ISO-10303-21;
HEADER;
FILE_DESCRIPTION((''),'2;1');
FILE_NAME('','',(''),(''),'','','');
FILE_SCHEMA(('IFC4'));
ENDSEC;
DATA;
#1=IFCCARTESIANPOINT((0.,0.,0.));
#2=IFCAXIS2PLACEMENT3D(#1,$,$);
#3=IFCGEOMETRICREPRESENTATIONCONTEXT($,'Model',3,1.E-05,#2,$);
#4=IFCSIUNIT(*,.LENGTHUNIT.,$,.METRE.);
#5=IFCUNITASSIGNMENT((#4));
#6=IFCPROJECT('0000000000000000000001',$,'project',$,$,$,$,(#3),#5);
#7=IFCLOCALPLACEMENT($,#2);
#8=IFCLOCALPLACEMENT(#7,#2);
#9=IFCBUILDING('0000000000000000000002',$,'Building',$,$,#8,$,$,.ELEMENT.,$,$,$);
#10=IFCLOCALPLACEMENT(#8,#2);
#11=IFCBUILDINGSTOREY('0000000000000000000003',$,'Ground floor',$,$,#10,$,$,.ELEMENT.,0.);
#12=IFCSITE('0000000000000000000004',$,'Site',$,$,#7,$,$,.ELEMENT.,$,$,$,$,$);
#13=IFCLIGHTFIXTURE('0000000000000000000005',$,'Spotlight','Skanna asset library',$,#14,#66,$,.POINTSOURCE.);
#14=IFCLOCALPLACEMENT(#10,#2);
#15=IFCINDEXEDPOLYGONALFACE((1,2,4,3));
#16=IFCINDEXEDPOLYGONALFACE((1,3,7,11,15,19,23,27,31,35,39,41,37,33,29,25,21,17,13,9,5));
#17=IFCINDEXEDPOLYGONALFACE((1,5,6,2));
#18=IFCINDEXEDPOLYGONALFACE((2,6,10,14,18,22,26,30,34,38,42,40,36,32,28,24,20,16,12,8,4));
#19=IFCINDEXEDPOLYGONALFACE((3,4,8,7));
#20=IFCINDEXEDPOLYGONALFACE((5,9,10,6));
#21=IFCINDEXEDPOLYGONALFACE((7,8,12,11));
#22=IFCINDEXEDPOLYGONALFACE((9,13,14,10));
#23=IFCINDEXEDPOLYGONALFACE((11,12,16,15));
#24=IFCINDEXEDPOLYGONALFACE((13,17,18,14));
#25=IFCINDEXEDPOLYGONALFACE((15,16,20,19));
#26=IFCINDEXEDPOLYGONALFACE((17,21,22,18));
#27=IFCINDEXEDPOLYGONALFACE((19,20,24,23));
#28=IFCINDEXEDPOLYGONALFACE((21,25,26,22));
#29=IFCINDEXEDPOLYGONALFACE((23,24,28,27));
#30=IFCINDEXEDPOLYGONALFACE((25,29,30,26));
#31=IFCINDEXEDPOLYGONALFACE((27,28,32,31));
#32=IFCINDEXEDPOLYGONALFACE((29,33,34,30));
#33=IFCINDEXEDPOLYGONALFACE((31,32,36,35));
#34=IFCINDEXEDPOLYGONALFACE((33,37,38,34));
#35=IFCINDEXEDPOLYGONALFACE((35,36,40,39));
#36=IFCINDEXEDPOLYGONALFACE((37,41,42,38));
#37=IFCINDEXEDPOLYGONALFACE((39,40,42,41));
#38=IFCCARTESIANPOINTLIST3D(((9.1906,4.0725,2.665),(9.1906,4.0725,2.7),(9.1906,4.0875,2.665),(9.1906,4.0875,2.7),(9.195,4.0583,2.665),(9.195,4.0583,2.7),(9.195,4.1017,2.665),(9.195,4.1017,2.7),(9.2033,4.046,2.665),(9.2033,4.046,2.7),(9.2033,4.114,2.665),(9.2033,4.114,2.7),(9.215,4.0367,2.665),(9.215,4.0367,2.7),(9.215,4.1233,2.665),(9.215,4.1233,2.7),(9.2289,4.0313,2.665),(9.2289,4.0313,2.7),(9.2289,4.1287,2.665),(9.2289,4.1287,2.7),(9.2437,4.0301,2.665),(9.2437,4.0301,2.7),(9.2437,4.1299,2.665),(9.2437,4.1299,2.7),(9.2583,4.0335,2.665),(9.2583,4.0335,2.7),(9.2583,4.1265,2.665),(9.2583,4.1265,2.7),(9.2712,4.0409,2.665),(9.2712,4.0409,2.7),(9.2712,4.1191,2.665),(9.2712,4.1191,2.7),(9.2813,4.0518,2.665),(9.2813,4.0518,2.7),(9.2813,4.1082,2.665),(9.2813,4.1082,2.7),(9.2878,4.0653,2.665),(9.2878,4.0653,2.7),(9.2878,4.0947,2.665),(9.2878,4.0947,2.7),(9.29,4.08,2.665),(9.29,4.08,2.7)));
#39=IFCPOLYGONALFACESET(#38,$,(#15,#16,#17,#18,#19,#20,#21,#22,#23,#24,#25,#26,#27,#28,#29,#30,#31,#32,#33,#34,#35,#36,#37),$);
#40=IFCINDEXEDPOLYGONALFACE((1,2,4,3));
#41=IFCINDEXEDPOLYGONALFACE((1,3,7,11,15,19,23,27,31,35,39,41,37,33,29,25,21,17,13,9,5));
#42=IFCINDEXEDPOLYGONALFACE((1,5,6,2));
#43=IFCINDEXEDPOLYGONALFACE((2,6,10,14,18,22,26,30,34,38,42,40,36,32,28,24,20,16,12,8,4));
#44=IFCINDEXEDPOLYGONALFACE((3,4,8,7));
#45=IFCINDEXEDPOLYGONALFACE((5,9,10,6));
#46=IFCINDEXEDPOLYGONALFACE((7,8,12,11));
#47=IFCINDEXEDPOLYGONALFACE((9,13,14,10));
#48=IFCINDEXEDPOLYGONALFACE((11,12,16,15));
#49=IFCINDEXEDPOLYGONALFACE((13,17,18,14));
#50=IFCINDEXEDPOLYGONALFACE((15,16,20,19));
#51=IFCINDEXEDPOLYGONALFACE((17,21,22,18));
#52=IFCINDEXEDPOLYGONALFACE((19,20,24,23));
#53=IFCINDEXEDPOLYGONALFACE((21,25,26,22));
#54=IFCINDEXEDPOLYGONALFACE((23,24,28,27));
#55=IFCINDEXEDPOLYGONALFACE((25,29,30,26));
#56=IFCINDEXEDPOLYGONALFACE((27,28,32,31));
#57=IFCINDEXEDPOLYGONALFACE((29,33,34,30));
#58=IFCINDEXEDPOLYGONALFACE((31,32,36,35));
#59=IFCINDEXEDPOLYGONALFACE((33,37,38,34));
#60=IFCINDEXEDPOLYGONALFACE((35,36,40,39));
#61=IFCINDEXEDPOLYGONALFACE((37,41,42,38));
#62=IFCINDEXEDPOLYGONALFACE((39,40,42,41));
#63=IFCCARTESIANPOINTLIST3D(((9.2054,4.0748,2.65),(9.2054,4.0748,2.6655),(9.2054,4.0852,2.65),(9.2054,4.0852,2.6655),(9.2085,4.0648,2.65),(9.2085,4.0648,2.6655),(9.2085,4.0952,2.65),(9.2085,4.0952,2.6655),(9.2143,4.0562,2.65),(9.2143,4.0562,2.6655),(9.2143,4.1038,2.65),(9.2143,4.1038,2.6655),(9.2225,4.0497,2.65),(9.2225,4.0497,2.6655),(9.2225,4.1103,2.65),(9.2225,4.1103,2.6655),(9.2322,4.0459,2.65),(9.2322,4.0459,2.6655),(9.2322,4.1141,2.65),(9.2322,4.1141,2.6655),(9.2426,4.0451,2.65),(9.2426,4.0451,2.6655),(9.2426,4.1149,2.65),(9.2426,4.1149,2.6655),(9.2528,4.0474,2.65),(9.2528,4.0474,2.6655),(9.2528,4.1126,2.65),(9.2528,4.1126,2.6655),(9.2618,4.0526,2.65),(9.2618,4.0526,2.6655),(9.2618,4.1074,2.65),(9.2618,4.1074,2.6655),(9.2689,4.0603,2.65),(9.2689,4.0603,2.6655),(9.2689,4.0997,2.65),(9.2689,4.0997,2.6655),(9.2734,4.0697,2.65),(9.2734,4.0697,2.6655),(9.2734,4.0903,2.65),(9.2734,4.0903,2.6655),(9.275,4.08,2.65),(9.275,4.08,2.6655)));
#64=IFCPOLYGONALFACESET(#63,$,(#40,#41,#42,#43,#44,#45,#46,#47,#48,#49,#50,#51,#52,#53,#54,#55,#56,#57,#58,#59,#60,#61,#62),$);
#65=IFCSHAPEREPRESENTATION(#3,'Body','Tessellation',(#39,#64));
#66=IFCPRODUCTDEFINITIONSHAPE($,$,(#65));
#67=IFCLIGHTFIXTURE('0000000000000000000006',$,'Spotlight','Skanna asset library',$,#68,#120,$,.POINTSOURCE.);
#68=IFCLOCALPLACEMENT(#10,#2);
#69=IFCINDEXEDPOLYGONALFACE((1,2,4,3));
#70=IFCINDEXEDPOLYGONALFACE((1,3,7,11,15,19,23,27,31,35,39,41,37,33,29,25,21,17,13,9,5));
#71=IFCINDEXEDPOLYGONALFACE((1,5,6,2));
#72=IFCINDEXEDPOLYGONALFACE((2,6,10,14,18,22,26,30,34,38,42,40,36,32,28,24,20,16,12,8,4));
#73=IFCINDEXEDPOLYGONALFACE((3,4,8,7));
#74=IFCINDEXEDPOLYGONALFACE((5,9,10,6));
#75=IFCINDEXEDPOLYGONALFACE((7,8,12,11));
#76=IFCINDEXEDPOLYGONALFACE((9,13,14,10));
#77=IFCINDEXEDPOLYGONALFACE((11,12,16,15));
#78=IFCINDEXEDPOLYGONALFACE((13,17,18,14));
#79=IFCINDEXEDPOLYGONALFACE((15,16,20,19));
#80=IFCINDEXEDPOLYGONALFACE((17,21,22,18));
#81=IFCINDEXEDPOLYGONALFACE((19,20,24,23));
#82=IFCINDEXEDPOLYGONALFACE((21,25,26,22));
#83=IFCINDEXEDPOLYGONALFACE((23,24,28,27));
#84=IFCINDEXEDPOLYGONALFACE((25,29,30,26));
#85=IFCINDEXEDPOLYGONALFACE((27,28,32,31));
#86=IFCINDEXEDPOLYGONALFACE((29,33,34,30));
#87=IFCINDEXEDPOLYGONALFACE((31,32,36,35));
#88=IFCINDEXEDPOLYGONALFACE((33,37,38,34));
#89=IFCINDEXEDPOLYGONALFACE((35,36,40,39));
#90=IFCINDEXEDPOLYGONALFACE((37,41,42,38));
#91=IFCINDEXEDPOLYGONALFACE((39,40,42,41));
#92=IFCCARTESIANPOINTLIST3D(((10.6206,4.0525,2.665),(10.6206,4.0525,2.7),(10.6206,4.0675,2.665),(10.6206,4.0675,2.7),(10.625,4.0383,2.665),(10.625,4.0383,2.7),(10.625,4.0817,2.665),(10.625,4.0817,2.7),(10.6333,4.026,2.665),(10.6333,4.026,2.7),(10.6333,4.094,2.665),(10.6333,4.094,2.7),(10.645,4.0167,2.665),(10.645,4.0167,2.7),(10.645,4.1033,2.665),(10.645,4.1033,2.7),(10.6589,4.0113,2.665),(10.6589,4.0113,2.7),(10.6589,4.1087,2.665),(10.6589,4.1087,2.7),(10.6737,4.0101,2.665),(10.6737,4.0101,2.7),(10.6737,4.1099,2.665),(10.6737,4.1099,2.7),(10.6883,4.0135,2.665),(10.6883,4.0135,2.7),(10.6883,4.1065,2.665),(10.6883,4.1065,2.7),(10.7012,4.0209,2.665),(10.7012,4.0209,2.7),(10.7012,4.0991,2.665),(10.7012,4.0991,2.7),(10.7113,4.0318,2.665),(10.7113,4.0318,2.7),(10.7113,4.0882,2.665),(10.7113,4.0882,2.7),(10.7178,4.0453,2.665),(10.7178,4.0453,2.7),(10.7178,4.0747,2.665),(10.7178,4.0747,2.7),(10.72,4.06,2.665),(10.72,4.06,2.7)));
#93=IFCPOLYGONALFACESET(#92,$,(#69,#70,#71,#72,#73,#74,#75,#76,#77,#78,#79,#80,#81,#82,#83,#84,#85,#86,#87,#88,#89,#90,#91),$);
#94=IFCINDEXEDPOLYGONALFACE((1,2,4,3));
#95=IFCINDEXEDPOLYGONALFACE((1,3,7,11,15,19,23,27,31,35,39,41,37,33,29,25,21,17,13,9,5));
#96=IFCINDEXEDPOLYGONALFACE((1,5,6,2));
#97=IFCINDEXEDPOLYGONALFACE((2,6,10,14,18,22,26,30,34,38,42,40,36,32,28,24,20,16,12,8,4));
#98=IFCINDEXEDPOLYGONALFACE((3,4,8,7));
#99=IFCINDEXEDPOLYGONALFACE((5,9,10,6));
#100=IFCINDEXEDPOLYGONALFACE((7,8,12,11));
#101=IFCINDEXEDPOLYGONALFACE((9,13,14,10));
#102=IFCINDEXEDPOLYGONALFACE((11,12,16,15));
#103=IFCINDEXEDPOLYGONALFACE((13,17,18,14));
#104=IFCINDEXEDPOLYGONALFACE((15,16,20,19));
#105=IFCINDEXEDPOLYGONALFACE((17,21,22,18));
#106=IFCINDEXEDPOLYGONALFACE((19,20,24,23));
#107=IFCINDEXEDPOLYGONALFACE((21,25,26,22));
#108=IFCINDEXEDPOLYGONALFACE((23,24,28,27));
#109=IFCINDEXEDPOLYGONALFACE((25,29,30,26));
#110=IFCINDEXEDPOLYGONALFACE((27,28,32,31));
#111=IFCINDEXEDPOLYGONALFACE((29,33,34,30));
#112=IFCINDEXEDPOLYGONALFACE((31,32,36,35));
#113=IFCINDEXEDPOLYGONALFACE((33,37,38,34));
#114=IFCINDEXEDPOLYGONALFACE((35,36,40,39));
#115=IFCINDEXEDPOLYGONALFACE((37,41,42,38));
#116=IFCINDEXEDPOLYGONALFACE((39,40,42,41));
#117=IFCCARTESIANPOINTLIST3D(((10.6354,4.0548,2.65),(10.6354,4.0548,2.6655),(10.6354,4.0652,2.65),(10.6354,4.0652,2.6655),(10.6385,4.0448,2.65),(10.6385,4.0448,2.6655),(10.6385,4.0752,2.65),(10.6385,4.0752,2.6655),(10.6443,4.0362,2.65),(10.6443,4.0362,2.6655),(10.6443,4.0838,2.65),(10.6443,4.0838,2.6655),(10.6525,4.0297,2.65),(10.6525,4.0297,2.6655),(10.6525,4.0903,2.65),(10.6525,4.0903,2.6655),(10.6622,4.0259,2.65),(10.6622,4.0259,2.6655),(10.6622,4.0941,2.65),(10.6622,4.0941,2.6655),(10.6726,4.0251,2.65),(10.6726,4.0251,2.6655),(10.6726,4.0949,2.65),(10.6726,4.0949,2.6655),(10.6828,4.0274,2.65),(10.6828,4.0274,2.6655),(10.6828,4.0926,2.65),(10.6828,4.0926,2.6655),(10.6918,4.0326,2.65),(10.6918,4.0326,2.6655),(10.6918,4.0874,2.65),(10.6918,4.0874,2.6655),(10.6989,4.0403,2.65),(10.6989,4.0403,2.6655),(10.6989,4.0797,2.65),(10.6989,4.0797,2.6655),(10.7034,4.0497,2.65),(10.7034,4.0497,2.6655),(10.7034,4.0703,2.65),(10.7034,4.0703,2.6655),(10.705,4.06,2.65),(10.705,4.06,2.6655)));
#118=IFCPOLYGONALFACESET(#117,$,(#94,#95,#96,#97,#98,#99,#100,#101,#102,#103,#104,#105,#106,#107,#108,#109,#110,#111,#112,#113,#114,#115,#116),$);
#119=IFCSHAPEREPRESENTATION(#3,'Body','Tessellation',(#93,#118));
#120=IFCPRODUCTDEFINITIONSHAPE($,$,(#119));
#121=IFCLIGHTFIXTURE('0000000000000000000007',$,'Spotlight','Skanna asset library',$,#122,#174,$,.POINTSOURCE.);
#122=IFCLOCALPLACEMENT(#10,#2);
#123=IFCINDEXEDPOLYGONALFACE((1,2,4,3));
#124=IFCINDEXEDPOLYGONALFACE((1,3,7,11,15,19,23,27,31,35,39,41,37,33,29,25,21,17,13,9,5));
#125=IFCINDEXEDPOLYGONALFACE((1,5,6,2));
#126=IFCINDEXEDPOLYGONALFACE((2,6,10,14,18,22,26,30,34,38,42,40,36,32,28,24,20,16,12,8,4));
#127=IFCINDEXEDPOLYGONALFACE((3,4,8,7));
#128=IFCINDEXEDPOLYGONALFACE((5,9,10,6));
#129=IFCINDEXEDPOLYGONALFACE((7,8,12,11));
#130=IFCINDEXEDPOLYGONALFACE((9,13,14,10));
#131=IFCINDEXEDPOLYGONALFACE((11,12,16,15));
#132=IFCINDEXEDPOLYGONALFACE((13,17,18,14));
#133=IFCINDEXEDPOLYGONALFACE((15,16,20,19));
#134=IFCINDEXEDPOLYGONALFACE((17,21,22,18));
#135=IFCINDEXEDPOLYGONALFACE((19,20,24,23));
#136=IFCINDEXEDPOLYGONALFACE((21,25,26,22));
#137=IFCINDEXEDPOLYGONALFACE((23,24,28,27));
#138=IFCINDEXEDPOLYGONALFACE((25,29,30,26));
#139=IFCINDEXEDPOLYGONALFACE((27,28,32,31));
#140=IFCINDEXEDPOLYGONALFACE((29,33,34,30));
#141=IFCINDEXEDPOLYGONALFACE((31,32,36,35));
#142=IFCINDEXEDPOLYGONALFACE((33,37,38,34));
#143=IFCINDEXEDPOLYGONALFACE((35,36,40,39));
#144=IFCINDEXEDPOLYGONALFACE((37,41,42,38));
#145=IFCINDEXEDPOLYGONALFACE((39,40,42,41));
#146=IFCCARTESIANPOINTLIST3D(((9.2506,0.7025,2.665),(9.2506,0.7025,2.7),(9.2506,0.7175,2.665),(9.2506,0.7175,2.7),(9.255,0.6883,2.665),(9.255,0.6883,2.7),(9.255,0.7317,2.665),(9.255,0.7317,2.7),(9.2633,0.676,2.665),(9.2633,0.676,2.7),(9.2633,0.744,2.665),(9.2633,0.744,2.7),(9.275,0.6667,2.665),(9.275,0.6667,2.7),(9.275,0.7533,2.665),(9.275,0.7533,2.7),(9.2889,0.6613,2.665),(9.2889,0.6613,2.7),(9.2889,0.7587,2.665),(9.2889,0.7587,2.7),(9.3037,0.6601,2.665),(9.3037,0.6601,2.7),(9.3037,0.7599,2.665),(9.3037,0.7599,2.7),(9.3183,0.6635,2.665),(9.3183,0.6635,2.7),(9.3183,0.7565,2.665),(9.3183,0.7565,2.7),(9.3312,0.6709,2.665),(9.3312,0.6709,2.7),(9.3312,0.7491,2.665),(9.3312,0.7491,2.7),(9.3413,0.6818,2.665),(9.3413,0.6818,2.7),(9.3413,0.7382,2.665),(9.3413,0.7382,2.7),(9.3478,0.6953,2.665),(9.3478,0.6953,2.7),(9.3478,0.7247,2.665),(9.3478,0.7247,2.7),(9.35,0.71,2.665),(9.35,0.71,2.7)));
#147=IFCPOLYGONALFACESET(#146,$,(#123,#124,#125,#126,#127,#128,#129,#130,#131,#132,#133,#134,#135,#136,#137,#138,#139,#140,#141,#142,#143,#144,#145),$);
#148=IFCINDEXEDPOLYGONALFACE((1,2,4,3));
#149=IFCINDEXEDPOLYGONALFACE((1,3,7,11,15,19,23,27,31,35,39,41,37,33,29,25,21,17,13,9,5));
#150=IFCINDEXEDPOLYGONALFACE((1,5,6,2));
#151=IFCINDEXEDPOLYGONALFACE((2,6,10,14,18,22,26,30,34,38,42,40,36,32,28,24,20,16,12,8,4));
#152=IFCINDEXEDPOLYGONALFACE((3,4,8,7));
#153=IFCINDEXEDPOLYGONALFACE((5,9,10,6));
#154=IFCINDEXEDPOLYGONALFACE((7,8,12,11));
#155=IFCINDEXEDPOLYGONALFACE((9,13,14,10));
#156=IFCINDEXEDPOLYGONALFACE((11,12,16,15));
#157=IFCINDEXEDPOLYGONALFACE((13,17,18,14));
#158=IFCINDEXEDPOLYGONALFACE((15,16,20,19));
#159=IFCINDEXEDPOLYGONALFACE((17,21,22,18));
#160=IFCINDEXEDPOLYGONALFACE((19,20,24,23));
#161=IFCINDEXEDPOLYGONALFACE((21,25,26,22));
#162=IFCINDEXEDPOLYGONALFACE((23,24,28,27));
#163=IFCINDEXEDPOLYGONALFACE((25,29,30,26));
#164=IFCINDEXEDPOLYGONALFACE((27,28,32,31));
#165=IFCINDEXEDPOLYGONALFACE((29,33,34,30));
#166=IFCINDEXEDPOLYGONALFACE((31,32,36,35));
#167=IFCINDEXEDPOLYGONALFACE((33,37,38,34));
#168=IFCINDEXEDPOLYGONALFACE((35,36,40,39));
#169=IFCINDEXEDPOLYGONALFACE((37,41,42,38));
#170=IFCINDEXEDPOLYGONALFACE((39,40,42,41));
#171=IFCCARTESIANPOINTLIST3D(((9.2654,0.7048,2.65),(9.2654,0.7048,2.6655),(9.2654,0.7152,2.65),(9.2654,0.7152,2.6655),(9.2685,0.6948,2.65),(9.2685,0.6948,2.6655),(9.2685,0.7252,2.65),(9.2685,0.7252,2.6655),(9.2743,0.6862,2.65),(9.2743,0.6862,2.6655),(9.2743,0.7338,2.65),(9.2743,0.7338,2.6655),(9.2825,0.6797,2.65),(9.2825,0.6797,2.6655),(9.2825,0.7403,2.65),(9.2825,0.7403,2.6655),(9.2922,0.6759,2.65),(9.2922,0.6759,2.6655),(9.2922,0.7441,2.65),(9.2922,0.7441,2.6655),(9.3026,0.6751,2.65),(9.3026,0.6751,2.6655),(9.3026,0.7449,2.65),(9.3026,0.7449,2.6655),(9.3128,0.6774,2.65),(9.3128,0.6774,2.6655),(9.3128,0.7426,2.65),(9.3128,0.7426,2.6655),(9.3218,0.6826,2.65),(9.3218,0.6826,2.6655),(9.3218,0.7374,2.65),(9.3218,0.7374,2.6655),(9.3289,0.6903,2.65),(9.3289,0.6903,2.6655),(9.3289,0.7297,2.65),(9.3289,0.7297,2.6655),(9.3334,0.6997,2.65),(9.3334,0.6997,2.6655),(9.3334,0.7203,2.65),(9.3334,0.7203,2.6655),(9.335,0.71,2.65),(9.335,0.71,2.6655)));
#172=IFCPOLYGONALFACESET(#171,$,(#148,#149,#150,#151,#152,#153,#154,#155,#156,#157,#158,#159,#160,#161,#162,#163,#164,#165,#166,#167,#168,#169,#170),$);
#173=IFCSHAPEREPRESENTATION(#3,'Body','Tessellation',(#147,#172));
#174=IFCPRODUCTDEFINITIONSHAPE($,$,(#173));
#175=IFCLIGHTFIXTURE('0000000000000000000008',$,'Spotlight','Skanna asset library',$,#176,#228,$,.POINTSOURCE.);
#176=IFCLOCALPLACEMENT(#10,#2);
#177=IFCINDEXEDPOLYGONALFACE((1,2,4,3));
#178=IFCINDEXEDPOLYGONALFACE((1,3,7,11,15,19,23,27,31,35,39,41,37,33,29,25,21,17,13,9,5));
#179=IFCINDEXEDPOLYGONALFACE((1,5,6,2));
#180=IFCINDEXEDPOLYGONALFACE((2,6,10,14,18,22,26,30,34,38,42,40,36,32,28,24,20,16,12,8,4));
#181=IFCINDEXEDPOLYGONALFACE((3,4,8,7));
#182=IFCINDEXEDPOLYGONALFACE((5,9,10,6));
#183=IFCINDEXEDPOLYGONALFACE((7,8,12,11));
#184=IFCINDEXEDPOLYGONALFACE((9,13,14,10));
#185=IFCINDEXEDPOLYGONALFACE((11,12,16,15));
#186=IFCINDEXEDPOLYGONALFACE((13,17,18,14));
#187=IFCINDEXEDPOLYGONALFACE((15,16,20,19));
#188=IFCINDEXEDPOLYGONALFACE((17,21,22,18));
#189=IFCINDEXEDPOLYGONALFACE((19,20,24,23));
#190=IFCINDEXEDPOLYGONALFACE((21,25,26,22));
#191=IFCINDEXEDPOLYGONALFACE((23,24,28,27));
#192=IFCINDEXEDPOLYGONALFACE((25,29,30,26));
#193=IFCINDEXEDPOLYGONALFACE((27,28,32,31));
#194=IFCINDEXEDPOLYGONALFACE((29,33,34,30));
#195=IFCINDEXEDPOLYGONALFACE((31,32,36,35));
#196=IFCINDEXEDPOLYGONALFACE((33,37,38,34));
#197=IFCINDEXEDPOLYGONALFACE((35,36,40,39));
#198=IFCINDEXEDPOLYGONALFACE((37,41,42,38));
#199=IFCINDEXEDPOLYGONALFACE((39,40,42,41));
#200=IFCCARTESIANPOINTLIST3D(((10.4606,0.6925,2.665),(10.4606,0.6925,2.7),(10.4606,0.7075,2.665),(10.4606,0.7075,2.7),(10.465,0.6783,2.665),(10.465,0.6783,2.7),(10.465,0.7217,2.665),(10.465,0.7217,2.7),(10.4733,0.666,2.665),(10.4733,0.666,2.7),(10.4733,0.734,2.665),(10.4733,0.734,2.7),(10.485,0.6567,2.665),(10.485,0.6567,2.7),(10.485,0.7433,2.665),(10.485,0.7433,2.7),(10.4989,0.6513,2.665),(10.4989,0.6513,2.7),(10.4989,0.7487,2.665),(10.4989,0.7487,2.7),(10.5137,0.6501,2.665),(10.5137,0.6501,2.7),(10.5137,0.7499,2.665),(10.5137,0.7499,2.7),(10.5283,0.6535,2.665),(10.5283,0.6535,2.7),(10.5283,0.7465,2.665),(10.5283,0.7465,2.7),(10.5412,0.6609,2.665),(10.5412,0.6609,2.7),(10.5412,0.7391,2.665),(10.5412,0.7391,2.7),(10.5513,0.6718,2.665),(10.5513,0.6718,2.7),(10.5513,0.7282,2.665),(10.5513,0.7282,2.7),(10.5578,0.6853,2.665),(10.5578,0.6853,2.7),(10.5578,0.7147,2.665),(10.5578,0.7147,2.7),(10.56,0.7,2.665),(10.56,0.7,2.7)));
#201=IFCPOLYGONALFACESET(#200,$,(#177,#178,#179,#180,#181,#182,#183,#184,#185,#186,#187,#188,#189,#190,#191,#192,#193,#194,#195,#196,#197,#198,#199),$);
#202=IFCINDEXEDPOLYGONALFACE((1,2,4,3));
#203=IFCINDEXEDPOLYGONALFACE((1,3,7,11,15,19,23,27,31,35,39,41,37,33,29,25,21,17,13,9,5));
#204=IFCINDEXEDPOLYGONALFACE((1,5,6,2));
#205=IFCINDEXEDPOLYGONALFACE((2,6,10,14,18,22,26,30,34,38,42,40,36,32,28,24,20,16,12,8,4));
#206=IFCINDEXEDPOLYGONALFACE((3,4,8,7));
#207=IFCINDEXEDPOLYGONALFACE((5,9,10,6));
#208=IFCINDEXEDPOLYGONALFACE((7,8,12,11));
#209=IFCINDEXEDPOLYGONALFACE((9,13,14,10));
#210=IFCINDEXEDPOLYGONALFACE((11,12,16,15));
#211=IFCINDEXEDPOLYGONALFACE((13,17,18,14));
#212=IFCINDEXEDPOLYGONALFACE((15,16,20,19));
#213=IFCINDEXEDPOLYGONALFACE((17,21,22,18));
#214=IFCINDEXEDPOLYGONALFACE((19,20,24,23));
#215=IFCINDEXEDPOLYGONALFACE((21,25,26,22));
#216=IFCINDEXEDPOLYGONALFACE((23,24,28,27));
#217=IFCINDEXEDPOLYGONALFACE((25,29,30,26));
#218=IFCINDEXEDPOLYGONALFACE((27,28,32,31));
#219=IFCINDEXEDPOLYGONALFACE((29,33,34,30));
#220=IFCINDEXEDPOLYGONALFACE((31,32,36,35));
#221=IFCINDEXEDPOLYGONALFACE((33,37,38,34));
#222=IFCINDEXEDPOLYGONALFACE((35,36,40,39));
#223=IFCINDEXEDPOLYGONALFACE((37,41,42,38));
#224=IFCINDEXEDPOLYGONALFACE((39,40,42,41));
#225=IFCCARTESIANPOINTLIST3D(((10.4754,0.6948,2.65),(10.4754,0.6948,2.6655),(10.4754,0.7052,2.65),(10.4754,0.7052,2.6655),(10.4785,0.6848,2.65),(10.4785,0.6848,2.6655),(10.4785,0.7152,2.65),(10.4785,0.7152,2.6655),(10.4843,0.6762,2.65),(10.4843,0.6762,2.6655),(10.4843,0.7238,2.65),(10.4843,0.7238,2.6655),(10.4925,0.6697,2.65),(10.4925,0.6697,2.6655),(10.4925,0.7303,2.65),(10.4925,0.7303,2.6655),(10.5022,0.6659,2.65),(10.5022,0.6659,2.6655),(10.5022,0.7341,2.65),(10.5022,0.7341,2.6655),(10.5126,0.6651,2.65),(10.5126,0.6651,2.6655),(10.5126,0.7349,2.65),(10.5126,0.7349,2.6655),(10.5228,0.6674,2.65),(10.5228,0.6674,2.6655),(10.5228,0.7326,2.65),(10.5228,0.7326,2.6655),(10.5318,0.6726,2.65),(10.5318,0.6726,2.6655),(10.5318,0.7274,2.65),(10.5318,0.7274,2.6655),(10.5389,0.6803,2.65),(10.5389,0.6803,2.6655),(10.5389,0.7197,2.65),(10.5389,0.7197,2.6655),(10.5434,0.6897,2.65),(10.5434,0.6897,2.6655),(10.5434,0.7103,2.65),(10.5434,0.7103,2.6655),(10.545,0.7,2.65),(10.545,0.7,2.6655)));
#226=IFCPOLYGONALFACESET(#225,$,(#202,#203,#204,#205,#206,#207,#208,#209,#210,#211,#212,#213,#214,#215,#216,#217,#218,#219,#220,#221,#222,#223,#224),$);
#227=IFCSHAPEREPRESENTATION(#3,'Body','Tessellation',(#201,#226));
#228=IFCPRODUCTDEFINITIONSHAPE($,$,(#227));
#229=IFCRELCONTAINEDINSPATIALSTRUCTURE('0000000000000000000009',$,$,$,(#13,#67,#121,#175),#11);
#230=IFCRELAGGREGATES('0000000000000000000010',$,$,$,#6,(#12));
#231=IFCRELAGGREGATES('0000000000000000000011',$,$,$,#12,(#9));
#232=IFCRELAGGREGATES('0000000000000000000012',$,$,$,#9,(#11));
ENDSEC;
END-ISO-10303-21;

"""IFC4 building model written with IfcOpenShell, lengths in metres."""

from ifc_helpers import new_model, si_unit, frame, origin, origin_2d, place, context, project, spatial, circle, extrude, element, save


model = new_model("IFC4")

# Units and contexts
model_context = context("Model", 3, precision=1e-05, world=origin())
ifc_project = project(units=[si_unit("LENGTHUNIT", "METRE")], contexts=[model_context])

# Site, building, storey
site_placement = place(None, origin())
site = spatial("IfcSite", under=ifc_project, at=site_placement, Name="Site", CompositionType="ELEMENT")
building_placement = place(site_placement, origin())
building = spatial("IfcBuilding", under=site, at=building_placement, Name="Building", CompositionType="ELEMENT")
storey_placement = place(building_placement, origin())
storey = spatial("IfcBuildingStorey", under=building, at=storey_placement, Name="Ground floor", CompositionType="ELEMENT", Elevation=0.0)

# Light fixtures
for number, where, z_axis, x_axis, name in (
    (1, (9.24, 4.08, 2.65), (0.0, 0.0, 1.0), (1.0, 0.0, 0.0), "Spotlight"),
    (2, (10.67, 4.06, 2.65), (0.0, 0.0, 1.0), (1.0, 0.0, 0.0), "Spotlight"),
    (3, (9.3, 0.71, 2.65), (0.0, 0.0, 1.0), (1.0, 0.0, 0.0), "Spotlight"),
    (4, (10.51, 0.7, 2.65), (0.0, 0.0, 1.0), (1.0, 0.0, 0.0), "Spotlight"),
):
    element("IfcLightFixture", number, at=place(storey_placement, frame(where, z_axis=z_axis, x_axis=x_axis)), inside=storey, Name=name, Description="Skanna asset library", PredefinedType="POINTSOURCE", context=model_context, shape_type="SweptSolid", body=[
        extrude(circle(Radius=0.05, at=origin_2d()), frame((0.0, 0.0, 0.015)), (0.0, 0.0, 1.0), 0.035),
        extrude(circle(Radius=0.035, at=origin_2d()), origin(), (0.0, 0.0, 1.0), 0.0155),
    ])

save(model, "model.ifc")
